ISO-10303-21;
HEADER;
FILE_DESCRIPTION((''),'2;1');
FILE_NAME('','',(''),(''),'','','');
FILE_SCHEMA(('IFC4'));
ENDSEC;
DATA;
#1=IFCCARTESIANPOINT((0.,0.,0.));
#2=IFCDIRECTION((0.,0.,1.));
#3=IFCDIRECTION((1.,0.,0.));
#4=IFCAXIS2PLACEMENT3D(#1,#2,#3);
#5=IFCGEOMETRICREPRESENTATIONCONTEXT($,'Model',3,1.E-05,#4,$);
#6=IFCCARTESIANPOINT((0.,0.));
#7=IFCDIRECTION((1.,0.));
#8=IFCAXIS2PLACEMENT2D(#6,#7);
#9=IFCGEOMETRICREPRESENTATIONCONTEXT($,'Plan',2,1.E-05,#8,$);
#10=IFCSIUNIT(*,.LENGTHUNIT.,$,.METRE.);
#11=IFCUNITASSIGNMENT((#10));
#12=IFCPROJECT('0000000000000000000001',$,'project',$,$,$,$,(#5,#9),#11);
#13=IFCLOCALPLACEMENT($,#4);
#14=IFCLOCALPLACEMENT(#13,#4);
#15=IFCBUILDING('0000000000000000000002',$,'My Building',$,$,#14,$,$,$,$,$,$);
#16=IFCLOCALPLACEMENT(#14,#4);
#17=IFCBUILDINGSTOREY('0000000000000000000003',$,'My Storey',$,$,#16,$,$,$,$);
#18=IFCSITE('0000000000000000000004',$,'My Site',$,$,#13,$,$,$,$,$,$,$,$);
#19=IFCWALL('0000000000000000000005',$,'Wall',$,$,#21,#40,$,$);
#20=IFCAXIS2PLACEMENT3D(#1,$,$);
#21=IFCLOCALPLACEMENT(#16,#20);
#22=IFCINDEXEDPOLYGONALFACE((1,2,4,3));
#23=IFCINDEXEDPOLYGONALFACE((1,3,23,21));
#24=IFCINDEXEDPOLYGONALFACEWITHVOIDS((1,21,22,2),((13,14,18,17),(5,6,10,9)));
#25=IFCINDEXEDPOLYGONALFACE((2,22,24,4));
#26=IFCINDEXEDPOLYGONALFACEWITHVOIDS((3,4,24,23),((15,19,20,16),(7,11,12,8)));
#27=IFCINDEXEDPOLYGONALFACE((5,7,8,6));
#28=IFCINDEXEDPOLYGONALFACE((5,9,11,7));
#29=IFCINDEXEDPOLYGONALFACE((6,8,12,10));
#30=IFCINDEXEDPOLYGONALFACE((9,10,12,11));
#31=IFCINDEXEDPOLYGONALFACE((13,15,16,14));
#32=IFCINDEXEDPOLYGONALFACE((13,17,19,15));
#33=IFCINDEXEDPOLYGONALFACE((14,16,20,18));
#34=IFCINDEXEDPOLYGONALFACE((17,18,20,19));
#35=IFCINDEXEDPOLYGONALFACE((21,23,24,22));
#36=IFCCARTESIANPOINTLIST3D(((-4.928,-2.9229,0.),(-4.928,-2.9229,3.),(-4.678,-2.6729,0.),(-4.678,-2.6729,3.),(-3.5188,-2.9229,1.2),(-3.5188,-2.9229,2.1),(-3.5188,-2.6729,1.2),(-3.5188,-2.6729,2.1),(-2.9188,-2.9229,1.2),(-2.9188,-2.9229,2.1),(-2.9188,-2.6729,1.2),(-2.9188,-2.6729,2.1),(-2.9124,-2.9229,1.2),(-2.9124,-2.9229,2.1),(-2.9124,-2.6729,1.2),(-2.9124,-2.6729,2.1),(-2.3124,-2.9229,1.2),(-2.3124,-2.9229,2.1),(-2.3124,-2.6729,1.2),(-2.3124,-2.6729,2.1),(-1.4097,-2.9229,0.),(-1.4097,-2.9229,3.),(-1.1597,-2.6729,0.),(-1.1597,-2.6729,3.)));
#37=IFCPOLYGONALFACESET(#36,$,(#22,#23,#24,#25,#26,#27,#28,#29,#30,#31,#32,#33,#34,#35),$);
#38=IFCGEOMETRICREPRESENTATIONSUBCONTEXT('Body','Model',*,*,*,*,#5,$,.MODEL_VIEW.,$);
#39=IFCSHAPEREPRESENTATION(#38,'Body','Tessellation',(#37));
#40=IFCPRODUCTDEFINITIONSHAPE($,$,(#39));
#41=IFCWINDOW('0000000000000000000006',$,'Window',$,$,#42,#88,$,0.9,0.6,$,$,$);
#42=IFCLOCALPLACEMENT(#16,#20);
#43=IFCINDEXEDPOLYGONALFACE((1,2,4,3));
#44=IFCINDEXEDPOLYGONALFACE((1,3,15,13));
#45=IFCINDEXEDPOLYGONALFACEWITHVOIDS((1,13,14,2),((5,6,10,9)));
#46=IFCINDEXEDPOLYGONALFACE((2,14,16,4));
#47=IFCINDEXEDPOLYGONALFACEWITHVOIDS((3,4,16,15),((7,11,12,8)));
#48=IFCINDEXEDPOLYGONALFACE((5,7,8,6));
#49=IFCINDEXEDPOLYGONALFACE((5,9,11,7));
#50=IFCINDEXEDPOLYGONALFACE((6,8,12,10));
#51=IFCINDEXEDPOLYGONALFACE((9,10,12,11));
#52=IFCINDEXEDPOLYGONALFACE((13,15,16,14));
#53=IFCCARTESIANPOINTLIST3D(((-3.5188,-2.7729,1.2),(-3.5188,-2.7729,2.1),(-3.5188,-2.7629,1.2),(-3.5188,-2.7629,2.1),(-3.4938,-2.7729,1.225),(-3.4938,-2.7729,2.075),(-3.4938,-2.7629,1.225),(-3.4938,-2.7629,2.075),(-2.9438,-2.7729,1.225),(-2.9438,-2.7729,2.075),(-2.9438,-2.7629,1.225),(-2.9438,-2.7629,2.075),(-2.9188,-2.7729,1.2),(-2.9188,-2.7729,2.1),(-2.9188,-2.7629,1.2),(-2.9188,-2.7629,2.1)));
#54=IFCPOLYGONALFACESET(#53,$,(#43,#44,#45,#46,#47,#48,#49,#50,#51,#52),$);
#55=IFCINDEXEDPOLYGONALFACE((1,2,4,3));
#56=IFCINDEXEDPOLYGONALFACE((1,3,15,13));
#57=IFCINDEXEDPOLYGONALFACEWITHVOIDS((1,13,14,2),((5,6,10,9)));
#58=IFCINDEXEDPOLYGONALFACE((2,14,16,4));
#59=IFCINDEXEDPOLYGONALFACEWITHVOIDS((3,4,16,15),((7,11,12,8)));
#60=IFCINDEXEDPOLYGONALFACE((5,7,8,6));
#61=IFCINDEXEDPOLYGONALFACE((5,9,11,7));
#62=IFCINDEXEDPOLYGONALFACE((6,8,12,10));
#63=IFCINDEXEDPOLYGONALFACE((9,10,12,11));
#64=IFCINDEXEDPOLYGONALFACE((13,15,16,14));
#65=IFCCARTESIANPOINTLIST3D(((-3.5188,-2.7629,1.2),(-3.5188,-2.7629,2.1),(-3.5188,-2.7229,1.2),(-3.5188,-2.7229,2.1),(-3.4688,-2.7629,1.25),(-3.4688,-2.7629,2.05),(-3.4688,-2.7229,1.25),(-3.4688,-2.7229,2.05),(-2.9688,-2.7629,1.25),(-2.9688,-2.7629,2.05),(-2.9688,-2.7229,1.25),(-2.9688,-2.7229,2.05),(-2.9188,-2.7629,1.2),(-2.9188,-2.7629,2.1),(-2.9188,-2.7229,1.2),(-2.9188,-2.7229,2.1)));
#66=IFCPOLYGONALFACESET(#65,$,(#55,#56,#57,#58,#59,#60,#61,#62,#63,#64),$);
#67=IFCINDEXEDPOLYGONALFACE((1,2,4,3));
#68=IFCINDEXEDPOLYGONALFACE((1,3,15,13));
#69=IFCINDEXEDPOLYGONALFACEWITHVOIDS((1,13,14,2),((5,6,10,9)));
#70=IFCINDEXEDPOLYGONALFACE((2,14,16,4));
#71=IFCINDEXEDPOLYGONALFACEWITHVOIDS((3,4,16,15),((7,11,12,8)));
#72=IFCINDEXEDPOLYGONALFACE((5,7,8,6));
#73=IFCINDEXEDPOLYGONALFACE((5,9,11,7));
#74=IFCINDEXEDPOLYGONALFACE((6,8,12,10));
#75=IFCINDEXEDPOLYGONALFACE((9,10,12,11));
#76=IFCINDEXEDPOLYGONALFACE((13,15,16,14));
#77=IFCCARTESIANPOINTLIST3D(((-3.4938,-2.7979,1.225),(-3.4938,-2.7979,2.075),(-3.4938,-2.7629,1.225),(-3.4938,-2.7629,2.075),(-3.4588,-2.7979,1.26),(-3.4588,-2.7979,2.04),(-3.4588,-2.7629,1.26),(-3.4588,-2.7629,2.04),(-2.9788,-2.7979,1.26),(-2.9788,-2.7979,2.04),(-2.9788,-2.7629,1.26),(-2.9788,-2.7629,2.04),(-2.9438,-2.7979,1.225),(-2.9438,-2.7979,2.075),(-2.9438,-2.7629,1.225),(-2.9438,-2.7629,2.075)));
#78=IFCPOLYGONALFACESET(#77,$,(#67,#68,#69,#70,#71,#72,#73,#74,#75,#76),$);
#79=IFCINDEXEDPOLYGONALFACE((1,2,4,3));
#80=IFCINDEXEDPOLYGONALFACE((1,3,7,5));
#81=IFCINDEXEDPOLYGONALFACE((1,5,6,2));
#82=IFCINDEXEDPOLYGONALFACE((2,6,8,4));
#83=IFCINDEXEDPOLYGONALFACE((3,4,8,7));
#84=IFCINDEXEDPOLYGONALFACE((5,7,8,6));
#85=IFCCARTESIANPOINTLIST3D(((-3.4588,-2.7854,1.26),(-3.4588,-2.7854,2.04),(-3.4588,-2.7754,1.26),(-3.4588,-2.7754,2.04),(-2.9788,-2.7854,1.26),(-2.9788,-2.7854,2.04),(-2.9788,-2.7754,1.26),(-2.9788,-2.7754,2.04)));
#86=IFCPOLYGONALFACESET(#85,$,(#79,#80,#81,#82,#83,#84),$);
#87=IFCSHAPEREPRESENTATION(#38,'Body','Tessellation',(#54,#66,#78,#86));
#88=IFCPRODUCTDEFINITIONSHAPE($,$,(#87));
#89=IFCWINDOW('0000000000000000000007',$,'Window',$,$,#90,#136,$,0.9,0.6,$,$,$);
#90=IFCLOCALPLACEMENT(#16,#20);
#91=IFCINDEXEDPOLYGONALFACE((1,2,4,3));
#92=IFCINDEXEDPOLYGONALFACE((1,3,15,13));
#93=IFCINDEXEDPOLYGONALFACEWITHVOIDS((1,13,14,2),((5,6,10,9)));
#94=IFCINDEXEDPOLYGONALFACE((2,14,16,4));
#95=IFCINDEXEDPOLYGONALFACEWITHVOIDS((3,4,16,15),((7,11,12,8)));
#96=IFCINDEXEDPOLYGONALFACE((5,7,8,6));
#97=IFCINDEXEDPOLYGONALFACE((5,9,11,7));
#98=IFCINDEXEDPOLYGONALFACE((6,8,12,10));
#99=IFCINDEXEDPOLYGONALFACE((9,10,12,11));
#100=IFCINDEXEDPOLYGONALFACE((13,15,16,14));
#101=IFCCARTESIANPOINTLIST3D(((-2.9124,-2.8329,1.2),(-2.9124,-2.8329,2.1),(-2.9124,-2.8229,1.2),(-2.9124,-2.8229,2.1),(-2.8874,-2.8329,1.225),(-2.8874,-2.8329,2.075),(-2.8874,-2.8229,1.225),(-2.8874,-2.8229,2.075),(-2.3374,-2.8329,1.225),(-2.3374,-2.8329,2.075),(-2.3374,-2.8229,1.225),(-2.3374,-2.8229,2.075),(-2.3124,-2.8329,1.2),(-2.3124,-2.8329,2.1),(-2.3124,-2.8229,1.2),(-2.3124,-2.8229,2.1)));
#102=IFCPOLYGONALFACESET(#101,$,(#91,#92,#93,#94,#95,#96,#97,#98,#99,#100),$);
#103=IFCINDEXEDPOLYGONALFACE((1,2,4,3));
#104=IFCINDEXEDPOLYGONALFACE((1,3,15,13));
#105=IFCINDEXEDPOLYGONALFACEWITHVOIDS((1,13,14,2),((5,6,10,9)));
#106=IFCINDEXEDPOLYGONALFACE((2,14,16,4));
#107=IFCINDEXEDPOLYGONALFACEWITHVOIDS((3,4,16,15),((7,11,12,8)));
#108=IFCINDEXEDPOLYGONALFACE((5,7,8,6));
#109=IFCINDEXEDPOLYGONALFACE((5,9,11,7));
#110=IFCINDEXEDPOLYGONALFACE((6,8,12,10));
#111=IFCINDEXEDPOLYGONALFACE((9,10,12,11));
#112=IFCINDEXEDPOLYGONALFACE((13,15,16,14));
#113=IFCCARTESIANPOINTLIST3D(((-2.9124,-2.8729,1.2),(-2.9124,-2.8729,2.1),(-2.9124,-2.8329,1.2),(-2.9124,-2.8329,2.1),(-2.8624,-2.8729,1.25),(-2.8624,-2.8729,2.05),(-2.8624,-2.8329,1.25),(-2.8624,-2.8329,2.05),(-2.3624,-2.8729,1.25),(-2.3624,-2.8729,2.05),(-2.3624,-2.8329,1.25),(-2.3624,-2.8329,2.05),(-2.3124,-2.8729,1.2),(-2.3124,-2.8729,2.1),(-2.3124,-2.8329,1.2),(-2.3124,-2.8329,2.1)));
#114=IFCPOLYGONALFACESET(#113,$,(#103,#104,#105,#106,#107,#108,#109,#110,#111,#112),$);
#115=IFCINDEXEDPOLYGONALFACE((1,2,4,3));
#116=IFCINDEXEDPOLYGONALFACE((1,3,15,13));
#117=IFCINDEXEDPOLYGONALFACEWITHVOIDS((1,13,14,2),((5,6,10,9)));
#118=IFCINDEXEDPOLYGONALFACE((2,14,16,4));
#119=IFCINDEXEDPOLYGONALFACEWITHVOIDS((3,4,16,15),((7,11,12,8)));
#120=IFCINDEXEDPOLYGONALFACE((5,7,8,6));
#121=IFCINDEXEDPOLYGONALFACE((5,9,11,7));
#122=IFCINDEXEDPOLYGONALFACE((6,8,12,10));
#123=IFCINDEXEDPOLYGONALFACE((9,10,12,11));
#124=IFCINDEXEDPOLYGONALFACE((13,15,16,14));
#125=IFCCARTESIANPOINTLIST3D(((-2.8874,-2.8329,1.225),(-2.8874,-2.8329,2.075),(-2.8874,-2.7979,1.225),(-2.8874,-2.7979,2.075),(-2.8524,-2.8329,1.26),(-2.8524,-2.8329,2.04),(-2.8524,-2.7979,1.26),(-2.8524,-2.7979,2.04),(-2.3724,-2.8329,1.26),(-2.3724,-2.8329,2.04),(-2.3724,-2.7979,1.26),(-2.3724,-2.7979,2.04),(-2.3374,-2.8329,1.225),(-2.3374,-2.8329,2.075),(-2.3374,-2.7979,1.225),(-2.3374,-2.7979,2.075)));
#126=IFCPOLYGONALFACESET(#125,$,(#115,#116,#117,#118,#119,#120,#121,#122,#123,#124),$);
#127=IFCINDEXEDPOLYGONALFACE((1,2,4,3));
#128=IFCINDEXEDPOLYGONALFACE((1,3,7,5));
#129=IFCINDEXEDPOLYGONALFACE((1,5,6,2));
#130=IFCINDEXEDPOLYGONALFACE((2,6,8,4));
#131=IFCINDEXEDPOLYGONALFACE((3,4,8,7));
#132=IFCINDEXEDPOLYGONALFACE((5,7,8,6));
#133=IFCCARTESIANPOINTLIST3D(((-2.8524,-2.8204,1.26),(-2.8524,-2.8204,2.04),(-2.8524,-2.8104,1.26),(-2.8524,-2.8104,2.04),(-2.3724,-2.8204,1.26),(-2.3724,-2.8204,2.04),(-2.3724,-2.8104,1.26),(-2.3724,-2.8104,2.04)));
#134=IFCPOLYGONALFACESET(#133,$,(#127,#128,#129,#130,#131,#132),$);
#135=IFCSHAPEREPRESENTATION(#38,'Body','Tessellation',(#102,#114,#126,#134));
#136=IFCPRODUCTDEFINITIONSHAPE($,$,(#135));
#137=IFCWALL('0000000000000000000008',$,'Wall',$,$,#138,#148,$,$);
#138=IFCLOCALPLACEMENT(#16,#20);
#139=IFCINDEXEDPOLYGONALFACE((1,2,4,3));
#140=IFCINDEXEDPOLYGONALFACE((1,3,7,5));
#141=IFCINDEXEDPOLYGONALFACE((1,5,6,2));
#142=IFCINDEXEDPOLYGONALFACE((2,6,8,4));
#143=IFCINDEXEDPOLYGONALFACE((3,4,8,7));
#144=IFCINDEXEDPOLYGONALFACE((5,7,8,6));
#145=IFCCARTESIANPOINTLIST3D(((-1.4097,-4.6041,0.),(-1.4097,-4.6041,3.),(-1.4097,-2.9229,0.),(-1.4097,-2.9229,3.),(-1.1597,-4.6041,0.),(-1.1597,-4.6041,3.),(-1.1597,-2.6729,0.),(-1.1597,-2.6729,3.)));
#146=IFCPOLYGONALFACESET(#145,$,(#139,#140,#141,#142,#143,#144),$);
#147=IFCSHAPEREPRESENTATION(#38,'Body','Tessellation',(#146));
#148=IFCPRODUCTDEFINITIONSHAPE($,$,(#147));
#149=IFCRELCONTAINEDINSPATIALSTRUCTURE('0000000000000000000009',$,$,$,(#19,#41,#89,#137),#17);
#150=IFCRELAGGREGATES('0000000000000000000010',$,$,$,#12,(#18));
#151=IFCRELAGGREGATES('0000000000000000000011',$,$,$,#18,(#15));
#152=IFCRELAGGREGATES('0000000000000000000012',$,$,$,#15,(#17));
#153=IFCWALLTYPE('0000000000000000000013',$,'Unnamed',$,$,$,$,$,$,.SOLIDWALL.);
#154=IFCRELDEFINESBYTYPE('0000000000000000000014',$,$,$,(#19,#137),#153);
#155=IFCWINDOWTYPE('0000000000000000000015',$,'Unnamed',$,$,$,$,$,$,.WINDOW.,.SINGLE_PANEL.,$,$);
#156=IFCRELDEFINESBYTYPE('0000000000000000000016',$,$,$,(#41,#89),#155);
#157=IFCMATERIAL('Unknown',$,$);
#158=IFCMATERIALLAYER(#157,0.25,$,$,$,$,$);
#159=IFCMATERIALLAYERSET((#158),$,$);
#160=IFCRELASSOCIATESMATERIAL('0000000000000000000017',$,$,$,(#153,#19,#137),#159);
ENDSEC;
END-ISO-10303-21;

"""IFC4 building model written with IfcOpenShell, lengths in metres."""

from ifc_helpers import new_model, entity, si_unit, frame, origin_with_axes, origin_2d_with_axis, place, context, subcontext, project, spatial, line, indexed_curve, outline, extrude, shape, source, transform, mapped, material, layer, layer_set, layer_usage, type_object, type_shapes, element, fill, save


model = new_model("IFC4")

# Units and contexts
model_context = context("Model", 3, precision=1e-05, world=origin_with_axes())
plan_context = context("Plan", 2, precision=1e-05, world=origin_2d_with_axis())
body_context_1 = subcontext(model_context, "Body", "Model", "MODEL_VIEW")
body_context_2 = subcontext(plan_context, "Body", "Plan", "PLAN_VIEW")
ifc_project = project(units=[si_unit("LENGTHUNIT", "METRE")], contexts=[model_context, plan_context])

# Site, building, storey
site_placement = place(None, origin_with_axes())
site = spatial("IfcSite", under=ifc_project, at=site_placement, Name="My Site")
building_placement = place(site_placement, origin_with_axes())
building = spatial("IfcBuilding", under=site, at=building_placement, Name="My Building")
storey_placement = place(building_placement, origin_with_axes())
storey = spatial("IfcBuildingStorey", under=building, at=storey_placement, Name="My Storey")

# Shared definitions
ifc_material = material(Name="Unknown")

# Wall, openings, windows
ifc_layer_1 = layer(ifc_material, 0.25)
ifc_layer_set_1 = layer_set([ifc_layer_1])
wall_type = type_object("IfcWallType", Name="Unnamed", PredefinedType="SOLIDWALL", material=ifc_layer_set_1)
shared_shape_1 = source(origin_with_axes(), body_context_1, "Body", "SweptSolid", [
    extrude(outline(indexed_curve([(0.0, 0.0), (0.6, 0.0), (0.6, 0.9), (0.0, 0.9)], segments=[line(1, 2, 3, 4, 1)])), frame((0.0, -0.6, 0.0), z_axis=(0.0, -1.0, 0.0), x_axis=(1.0, 0.0, 0.0)), (0.0, 0.0, -1.0), 1.2),
])
window_type = type_object("IfcWindowType", Name="Unnamed", PartitioningType="SINGLE_PANEL", PredefinedType="WINDOW")
shared_shape_2 = source(origin_with_axes(), body_context_1, "Body", "SweptSolid", [
    extrude(outline(indexed_curve([(0.0, 0.0), (0.6, 0.0), (0.6, 0.9), (0.0, 0.9)], segments=[line(1, 2, 3, 4, 1)]), holes=[indexed_curve([(0.025, 0.025), (0.575, 0.025), (0.575, 0.875), (0.025, 0.875)], segments=[line(1, 2, 3, 4, 1)])]), frame((0.0, 0.09, 0.0), z_axis=(0.0, -1.0, 0.0), x_axis=(1.0, 0.0, 0.0)), (0.0, 0.0, -1.0), 0.01),
    extrude(outline(indexed_curve([(0.0, 0.0), (0.6, 0.0), (0.6, 0.9), (0.0, 0.9)], segments=[line(1, 2, 3, 4, 1)]), holes=[indexed_curve([(0.05, 0.05), (0.55, 0.05), (0.55, 0.85), (0.05, 0.85)], segments=[line(1, 2, 3, 4, 1)])]), frame((0.0, 0.05, 0.0), z_axis=(0.0, -1.0, 0.0), x_axis=(1.0, 0.0, 0.0)), (0.0, 0.0, -1.0), 0.04),
    extrude(outline(indexed_curve([(0.0, 0.0), (0.55, 0.0), (0.55, 0.85), (0.0, 0.85)], segments=[line(1, 2, 3, 4, 1)]), holes=[indexed_curve([(0.035, 0.035), (0.515, 0.035), (0.515, 0.815), (0.035, 0.815)], segments=[line(1, 2, 3, 4, 1)])]), frame((0.025, 0.09, 0.025), z_axis=(0.0, -1.0, 0.0), x_axis=(1.0, 0.0, 0.0)), (0.0, 0.0, -1.0), 0.035),
    extrude(outline(indexed_curve([(0.035, 0.035), (0.515, 0.035), (0.515, 0.815), (0.035, 0.815)], segments=[line(1, 2, 3, 4, 1)])), frame((0.025, 0.1025, 0.025), z_axis=(0.0, -1.0, 0.0), x_axis=(1.0, 0.0, 0.0)), (0.0, 0.0, -1.0), 0.01),
])
shared_shape_3 = source(origin_with_axes(), body_context_2, "Body", "Curve2D", [
    entity("IfcIndexedPolyCurve", entity("IfcCartesianPointList2D", [[0.05, 0.05], [0.55, 0.05]])),
    entity("IfcIndexedPolyCurve", entity("IfcCartesianPointList2D", [[0.0, 0.1], [0.025, 0.1], [0.025, 0.09], [0.05, 0.09], [0.05, 0.05], [0.0, 0.05]]), [entity("IfcLineIndex", [1, 2, 3, 4, 5, 6, 1])]),
    entity("IfcIndexedPolyCurve", entity("IfcCartesianPointList2D", [[0.6, 0.1], [0.575, 0.1], [0.575, 0.09], [0.55, 0.09], [0.55, 0.05], [0.6, 0.05]]), [entity("IfcLineIndex", [1, 2, 3, 4, 5, 6, 1])]),
    entity("IfcIndexedPolyCurve", entity("IfcCartesianPointList2D", [[0.025, 0.09], [0.06, 0.09], [0.06, 0.125], [0.025, 0.125]]), [entity("IfcLineIndex", [1, 2, 3, 4, 1])]),
    entity("IfcIndexedPolyCurve", entity("IfcCartesianPointList2D", [[0.575, 0.09], [0.54, 0.09], [0.54, 0.125], [0.575, 0.125]]), [entity("IfcLineIndex", [1, 2, 3, 4, 1])]),
    entity("IfcIndexedPolyCurve", entity("IfcCartesianPointList2D", [[0.06, 0.09], [0.54, 0.09]])),
    entity("IfcIndexedPolyCurve", entity("IfcCartesianPointList2D", [[0.06, 0.125], [0.54, 0.125]])),
    entity("IfcIndexedPolyCurve", entity("IfcCartesianPointList2D", [[0.06, 0.1075], [0.54, 0.1075]])),
])
type_shapes(window_type, [shared_shape_2, shared_shape_3])
ifc_layer_usage_1 = layer_usage(ifc_layer_set_1, "AXIS2", "POSITIVE", 0.0)
wall_1_placement = place(storey_placement, frame((-4.928, -2.9229, 0.0), z_axis=(0.0, 0.0, 1.0), x_axis=(1.0, 0.0, 0.0)))
wall_1 = element("IfcWall", 1, at=wall_1_placement, inside=storey, type_object=wall_type, material=ifc_layer_usage_1, Name="Wall", context=body_context_1, shape_type="SweptSolid", body=[
    extrude(outline(indexed_curve([(0.0, 0.0), (0.25, 0.25), (3.7684, 0.25), (3.5184, 0.0)], segments=[line(1, 2, 3, 4, 1)])), origin_with_axes(), (0.0, 0.0, 1.0), 3.0),
])
opening_1_placement = place(wall_1_placement, frame((2.0092, 0.25, 1.2), z_axis=(0.0, 0.0, 1.0), x_axis=(-1.0, 0.0, 0.0)))
opening_1 = element("IfcOpeningElement", 2, at=opening_1_placement, cuts=wall_1, PredefinedType="OPENING", context=body_context_1, shape_type="MappedRepresentation", body=[
    mapped(shared_shape_1, transform((0.0, 0.0, 0.0), x_axis=(1.0, 0.0, 0.0), y_axis=(0.0, 1.0, 0.0), z_axis=(0.0, 0.0, 1.0), scale=1.0)),
])
opening_2_placement = place(wall_1_placement, frame((2.0157, 0.0, 1.2), z_axis=(0.0, 0.0, 1.0), x_axis=(1.0, 0.0, 0.0)))
opening_2 = element("IfcOpeningElement", 3, at=opening_2_placement, cuts=wall_1, PredefinedType="OPENING", context=body_context_1, shape_type="MappedRepresentation", body=[
    mapped(shared_shape_1, transform((0.0, 0.0, 0.0), x_axis=(1.0, 0.0, 0.0), y_axis=(0.0, 1.0, 0.0), z_axis=(0.0, 0.0, 1.0), scale=1.0)),
])
window_1_placement = place(opening_1_placement, frame((0.0, 0.0, 0.0), z_axis=(0.0, 0.0, 1.0), x_axis=(1.0, 0.0, 0.0)))
window_1 = element("IfcWindow", 4, at=window_1_placement, inside=storey, type_object=window_type, Name="Window", OverallHeight=0.9, OverallWidth=0.6, shapes=[
    shape(body_context_1, "Body", "MappedRepresentation", [mapped(shared_shape_2, transform((0.0, 0.0, 0.0), x_axis=(1.0, 0.0, 0.0), y_axis=(0.0, 1.0, 0.0), z_axis=(0.0, 0.0, 1.0), scale=1.0))]),
    shape(body_context_2, "Body", "MappedRepresentation", [mapped(shared_shape_3, transform((0.0, 0.0, 0.0), x_axis=(1.0, 0.0, 0.0), y_axis=(0.0, 1.0, 0.0), z_axis=(0.0, 0.0, 1.0), scale=1.0))]),
])
fill(opening_1, window_1)
window_2_placement = place(opening_2_placement, origin_with_axes())
window_2 = element("IfcWindow", 5, at=window_2_placement, inside=storey, type_object=window_type, Name="Window", OverallHeight=0.9, OverallWidth=0.6, shapes=[
    shape(body_context_1, "Body", "MappedRepresentation", [mapped(shared_shape_2, transform((0.0, 0.0, 0.0), x_axis=(1.0, 0.0, 0.0), y_axis=(0.0, 1.0, 0.0), z_axis=(0.0, 0.0, 1.0), scale=1.0))]),
    shape(body_context_2, "Body", "MappedRepresentation", [mapped(shared_shape_3, transform((0.0, 0.0, 0.0), x_axis=(1.0, 0.0, 0.0), y_axis=(0.0, 1.0, 0.0), z_axis=(0.0, 0.0, 1.0), scale=1.0))]),
])
fill(opening_2, window_2)

# Wall
ifc_layer_usage_2 = layer_usage(ifc_layer_set_1, "AXIS2", "POSITIVE", 0.0)
wall_2_placement = place(storey_placement, frame((-1.4097, -2.9229, 0.0), z_axis=(0.0, 0.0, 1.0), x_axis=(0.0, -1.0, 0.0)))
element("IfcWall", 6, at=wall_2_placement, inside=storey, type_object=wall_type, material=ifc_layer_usage_2, Name="Wall", context=body_context_1, shape_type="SweptSolid", body=[
    extrude(outline(indexed_curve([(0.0, 0.0), (-0.25, 0.25), (1.6811, 0.25), (1.6811, 0.0)], segments=[line(1, 2, 3, 4, 1)])), origin_with_axes(), (0.0, 0.0, 1.0), 3.0),
])

save(model, "model.ifc")
